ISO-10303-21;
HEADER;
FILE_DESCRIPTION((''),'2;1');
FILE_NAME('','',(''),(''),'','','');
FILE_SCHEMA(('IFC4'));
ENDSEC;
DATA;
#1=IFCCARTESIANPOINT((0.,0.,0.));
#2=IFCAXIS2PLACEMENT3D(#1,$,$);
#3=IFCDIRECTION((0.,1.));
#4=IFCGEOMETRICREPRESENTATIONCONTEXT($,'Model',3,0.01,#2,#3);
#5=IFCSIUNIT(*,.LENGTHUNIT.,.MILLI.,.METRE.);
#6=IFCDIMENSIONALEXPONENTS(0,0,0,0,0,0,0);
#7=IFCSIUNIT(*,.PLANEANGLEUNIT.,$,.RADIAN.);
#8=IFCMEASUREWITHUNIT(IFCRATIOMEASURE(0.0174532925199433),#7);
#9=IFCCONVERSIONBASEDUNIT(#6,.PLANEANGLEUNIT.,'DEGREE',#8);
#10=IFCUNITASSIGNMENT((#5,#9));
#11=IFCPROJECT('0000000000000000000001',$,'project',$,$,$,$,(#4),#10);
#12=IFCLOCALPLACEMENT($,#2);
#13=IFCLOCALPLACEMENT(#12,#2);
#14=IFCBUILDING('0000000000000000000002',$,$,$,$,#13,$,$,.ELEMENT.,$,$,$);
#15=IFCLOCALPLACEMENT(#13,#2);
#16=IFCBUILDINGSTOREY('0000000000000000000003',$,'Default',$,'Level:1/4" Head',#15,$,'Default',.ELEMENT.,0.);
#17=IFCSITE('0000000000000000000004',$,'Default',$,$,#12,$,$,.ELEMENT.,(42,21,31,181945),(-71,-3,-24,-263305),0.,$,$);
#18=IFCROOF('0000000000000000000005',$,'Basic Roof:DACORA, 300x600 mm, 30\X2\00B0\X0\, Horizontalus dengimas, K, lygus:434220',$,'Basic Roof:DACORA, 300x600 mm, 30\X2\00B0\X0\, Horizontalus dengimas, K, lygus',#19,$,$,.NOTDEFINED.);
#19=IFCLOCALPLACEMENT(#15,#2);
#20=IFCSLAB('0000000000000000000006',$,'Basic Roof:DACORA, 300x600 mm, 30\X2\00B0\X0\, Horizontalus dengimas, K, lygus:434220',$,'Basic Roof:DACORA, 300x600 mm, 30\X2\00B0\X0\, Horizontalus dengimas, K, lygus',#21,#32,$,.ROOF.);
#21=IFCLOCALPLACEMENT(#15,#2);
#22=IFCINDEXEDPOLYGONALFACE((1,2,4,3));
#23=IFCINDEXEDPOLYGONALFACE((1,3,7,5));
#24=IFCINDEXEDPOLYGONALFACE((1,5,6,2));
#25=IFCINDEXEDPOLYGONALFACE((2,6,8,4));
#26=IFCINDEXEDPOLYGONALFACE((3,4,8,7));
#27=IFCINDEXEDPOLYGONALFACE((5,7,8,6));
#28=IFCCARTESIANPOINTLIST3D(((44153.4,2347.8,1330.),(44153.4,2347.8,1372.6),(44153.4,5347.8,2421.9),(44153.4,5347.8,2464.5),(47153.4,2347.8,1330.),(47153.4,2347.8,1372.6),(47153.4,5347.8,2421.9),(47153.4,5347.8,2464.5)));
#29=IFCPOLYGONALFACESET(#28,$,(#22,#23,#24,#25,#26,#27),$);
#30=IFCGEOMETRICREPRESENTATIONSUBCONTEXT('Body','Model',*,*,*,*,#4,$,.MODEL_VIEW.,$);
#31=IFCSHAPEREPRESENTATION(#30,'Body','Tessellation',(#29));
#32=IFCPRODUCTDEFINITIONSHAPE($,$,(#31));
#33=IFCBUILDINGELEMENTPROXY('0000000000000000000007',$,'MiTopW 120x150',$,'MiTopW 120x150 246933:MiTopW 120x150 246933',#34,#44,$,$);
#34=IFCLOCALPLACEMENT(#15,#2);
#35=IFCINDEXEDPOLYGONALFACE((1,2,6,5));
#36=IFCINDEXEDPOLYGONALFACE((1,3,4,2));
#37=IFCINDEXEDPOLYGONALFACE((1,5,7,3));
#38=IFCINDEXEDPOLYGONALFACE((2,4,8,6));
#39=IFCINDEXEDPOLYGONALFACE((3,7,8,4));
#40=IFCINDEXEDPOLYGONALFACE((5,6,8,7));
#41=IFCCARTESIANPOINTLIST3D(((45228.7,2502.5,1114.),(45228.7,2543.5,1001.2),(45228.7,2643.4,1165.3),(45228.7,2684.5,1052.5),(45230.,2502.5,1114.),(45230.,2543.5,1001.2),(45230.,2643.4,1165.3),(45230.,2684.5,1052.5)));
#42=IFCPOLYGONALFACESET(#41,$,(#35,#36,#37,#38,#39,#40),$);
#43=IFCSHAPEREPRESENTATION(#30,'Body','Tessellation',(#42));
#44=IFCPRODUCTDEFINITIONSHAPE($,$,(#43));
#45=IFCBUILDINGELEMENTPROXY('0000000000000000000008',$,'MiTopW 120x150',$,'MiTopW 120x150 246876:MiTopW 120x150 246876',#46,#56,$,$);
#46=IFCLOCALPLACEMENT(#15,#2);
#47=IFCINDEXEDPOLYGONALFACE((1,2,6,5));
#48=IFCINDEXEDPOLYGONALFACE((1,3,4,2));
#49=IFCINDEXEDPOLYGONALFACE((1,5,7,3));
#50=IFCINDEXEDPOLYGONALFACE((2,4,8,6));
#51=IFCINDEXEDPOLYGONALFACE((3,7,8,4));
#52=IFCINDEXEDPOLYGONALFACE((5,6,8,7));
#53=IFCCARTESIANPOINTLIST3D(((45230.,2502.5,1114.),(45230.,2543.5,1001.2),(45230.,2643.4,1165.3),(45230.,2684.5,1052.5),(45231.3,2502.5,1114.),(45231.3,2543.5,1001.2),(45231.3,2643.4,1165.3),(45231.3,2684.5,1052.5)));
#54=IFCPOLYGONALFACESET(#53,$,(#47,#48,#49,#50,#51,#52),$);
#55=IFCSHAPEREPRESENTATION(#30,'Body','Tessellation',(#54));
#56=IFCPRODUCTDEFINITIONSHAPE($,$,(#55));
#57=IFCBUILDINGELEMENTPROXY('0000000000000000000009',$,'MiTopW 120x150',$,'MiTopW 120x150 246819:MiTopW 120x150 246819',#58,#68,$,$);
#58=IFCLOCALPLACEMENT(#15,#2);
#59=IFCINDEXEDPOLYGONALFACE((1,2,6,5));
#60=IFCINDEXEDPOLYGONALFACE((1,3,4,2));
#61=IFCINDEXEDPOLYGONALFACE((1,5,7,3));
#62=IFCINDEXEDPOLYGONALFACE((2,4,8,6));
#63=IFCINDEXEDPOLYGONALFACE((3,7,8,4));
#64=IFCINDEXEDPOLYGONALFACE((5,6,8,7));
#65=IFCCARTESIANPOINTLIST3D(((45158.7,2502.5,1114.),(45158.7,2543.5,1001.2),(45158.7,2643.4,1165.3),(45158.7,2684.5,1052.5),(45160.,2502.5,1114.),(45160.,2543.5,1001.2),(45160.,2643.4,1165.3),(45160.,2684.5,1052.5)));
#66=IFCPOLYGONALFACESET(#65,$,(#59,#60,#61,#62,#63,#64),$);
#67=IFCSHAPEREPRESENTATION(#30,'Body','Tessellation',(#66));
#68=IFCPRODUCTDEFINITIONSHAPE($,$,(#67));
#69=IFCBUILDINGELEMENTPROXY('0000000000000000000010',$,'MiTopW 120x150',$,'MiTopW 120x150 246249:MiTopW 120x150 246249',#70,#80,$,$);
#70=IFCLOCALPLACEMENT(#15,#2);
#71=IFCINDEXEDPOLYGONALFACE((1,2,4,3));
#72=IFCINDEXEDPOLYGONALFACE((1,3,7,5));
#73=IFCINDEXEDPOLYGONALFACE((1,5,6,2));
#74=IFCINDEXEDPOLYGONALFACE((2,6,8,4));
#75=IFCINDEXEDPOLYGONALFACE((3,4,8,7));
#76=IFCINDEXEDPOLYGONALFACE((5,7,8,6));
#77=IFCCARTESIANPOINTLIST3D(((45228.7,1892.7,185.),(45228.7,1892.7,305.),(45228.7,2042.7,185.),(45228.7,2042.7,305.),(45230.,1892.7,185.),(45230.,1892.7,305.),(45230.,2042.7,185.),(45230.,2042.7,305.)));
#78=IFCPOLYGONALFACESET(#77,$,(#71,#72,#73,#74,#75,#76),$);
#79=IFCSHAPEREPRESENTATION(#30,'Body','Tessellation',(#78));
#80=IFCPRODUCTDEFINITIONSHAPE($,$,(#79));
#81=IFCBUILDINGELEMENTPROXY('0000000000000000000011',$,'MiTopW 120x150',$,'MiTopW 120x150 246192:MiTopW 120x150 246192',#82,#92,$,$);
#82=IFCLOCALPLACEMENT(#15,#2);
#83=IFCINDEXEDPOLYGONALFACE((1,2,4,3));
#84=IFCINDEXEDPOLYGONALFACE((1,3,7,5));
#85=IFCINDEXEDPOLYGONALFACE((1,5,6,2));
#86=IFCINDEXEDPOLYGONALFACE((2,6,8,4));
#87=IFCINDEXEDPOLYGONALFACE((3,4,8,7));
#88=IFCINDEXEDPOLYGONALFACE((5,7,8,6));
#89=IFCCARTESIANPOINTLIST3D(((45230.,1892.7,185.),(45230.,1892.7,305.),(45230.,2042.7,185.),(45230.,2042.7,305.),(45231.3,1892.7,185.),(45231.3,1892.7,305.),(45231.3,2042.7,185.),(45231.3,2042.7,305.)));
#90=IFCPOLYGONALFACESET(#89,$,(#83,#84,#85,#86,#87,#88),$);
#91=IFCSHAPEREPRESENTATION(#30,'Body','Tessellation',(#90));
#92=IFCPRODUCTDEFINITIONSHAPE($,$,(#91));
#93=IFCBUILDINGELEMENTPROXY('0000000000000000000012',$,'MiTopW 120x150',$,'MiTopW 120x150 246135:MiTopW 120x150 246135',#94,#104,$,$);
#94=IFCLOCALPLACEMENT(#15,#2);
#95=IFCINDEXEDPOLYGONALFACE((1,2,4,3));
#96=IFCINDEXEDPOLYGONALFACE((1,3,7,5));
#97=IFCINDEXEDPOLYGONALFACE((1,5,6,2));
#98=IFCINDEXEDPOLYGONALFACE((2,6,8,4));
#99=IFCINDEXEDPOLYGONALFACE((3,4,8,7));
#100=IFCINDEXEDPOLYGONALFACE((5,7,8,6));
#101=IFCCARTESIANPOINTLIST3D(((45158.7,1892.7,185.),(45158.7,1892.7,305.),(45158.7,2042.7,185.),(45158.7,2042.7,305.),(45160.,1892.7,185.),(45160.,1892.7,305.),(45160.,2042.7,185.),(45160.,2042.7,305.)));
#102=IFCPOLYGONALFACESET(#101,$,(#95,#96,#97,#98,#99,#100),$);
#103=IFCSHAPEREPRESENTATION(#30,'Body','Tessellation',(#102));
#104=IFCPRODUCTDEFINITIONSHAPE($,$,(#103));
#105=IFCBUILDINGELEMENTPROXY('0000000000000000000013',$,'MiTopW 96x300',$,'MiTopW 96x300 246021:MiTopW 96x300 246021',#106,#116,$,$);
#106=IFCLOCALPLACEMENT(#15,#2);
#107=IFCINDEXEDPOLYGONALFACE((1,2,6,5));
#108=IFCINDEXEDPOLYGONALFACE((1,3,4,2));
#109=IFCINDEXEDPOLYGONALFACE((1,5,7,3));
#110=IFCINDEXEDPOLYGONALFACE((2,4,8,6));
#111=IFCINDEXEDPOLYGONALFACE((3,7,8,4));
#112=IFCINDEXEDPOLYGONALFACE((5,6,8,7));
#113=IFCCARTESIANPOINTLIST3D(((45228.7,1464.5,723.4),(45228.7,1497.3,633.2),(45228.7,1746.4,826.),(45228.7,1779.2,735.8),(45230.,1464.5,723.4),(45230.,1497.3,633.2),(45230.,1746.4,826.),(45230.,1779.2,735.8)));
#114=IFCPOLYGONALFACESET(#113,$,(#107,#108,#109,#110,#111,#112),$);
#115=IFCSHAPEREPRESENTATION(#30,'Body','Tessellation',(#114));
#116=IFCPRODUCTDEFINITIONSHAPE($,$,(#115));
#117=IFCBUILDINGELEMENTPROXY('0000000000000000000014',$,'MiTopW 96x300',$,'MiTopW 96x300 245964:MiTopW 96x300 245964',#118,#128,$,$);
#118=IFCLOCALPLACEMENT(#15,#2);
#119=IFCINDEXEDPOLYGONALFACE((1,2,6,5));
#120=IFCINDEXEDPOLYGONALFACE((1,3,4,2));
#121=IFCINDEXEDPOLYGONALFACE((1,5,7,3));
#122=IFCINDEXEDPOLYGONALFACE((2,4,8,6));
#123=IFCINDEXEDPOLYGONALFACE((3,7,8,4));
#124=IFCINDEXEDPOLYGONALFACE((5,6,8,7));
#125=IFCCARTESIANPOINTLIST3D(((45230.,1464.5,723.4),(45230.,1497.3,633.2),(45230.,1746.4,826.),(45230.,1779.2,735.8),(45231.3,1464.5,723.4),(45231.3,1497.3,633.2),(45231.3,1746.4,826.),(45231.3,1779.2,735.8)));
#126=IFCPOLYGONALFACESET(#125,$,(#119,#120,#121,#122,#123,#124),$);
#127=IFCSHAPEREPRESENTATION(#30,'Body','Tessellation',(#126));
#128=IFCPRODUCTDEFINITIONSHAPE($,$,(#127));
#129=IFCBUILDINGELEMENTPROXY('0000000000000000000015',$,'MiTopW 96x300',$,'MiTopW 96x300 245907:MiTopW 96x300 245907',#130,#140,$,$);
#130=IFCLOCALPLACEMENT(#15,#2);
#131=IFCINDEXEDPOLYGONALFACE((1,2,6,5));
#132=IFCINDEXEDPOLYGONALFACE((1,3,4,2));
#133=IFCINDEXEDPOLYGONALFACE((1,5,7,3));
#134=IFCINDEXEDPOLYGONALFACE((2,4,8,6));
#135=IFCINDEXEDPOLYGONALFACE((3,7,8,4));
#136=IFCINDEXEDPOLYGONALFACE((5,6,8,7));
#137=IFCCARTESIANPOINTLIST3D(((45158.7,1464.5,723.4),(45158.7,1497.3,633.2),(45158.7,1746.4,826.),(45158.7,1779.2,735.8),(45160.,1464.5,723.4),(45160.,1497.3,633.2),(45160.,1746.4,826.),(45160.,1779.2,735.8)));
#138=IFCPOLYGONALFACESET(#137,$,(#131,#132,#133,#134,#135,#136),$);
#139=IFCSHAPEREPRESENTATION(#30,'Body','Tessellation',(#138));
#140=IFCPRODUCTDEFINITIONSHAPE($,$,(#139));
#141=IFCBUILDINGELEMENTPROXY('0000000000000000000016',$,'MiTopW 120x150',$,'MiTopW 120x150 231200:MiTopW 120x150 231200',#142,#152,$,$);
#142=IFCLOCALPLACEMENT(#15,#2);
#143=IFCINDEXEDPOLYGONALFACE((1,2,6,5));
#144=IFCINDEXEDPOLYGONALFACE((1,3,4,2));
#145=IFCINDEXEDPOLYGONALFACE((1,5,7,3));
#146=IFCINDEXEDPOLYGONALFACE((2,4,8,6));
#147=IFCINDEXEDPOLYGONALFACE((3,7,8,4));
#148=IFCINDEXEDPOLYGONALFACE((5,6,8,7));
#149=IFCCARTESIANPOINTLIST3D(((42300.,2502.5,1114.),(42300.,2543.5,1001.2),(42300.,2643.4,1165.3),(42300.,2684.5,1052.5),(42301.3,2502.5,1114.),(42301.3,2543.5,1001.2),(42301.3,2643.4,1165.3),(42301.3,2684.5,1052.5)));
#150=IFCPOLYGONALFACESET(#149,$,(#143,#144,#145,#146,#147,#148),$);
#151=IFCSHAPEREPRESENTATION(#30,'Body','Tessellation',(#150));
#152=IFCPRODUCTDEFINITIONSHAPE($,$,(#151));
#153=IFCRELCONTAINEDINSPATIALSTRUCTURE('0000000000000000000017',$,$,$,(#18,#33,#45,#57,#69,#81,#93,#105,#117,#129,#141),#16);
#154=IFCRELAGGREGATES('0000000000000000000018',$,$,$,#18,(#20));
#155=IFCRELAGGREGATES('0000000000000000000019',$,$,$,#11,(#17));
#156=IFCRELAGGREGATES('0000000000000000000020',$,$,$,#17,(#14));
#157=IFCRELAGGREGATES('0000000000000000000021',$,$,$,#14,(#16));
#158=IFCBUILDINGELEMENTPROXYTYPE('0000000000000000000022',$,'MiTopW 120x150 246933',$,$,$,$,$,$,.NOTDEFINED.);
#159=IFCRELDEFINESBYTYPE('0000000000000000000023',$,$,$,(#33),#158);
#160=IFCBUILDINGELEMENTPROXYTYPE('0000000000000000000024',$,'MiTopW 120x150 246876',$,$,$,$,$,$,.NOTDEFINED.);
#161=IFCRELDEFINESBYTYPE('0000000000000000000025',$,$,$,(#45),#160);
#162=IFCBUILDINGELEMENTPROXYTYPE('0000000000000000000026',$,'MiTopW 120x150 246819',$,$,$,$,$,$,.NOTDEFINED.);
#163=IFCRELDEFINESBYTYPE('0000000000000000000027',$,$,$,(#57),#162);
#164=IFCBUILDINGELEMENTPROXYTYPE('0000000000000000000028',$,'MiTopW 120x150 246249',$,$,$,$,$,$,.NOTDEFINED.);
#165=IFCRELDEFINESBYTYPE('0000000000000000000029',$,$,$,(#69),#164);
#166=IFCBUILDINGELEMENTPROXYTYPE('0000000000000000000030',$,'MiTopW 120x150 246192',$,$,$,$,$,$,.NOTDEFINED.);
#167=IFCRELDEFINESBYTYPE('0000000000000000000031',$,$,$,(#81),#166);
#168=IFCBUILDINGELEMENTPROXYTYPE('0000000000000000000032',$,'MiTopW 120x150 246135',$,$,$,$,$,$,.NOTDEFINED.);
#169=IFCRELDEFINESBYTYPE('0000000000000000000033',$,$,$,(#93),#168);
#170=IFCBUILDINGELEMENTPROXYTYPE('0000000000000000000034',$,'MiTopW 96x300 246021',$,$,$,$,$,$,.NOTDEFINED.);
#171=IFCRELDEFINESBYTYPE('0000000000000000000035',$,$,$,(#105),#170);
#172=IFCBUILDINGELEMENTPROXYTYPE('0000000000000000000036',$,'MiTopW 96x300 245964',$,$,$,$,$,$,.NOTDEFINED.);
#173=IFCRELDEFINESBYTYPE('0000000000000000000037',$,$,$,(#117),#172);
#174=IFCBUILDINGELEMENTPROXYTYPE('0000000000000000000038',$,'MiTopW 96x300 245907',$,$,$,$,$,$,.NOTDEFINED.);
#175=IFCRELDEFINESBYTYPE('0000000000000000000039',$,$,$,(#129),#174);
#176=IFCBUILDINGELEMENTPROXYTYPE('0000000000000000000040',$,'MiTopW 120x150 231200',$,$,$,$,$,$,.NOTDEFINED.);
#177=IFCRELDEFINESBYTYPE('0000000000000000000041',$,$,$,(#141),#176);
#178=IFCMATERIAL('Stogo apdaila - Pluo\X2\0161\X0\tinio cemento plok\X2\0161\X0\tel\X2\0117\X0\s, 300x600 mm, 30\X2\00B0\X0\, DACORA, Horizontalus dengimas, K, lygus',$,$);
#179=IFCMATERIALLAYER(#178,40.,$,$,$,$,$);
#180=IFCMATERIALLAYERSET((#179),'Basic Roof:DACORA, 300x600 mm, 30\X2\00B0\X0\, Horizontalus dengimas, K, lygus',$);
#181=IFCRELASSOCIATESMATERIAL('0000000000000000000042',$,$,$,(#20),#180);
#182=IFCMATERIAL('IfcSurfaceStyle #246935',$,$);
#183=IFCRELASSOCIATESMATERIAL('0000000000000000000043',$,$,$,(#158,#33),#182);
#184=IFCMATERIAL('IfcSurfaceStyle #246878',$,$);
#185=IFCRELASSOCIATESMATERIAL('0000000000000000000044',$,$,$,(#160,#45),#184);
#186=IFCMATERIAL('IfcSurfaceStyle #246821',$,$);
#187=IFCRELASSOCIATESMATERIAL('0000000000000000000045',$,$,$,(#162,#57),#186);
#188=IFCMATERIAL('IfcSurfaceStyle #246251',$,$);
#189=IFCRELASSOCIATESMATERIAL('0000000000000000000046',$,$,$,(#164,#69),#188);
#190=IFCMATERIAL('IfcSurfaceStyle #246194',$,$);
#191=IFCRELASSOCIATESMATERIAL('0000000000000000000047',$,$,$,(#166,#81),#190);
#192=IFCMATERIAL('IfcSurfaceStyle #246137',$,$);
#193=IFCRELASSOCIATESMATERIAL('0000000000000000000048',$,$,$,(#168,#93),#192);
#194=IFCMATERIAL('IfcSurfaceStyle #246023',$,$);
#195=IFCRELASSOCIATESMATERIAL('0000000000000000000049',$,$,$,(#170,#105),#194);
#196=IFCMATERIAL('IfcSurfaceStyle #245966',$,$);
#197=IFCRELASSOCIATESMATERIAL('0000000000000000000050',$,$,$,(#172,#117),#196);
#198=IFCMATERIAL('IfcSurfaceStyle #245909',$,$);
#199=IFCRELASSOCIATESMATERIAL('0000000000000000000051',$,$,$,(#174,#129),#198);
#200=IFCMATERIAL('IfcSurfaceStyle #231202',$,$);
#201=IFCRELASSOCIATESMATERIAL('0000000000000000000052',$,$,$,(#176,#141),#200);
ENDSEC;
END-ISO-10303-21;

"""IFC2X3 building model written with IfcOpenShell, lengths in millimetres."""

from ifc_helpers import new_model, entity, si_unit, converted_unit, direction, frame, frame_2d, origin, origin_2d_with_axis, place, context, subcontext, project, spatial, polyline, rectangle, outline, extrude, source, transform, mapped, material, layer, layer_set, type_object, type_shapes, element, aggregate, save


model = new_model("IFC2X3")

# Units and contexts
model_context = context("Model", 3, precision=0.01, world=origin(), true_north=direction((0.0, 1.0)))
body_context = subcontext(model_context, "Body", "Model", "MODEL_VIEW")
ifc_project = project(units=[si_unit("LENGTHUNIT", "METRE", prefix="MILLI"), converted_unit("PLANEANGLEUNIT", "DEGREE", entity("IfcRatioMeasure", 0.0174532925199433), si_unit("PLANEANGLEUNIT", "RADIAN"), dimensions=[0, 0, 0, 0, 0, 0, 0])], contexts=[model_context])

# Site, building, storey
site_placement = place(None, origin())
site = spatial("IfcSite", under=ifc_project, at=site_placement, Name="Default", CompositionType="ELEMENT", RefLatitude=(42, 21, 31, 181945), RefLongitude=(-71, -3, -24, -263305), RefElevation=0.0)
building_placement = place(site_placement, origin())
building = spatial("IfcBuilding", under=site, at=building_placement, CompositionType="ELEMENT")
storey_placement = place(building_placement, origin())
storey = spatial("IfcBuildingStorey", under=building, at=storey_placement, Name="Default", ObjectType="Level:1/4\" Head", LongName="Default", CompositionType="ELEMENT", Elevation=0.0)

# Roof, slab
roof_placement = place(storey_placement, frame((44153.4, 2347.8, 1330.0)))
roof = element("IfcRoof", 1, at=roof_placement, inside=storey, Name="Basic Roof:DACORA, 300x600 mm, 30°, Horizontalus dengimas, K, lygus:434220", ObjectType="Basic Roof:DACORA, 300x600 mm, 30°, Horizontalus dengimas, K, lygus", ShapeType="NOTDEFINED")
ifc_material_1 = material(Name="Stogo apdaila - Pluoštinio cemento plokštelės, 300x600 mm, 30°, DACORA, Horizontalus dengimas, K, lygus")
ifc_layer = layer(ifc_material_1, 40.0)
ifc_layer_set = layer_set([ifc_layer], Name="Basic Roof:DACORA, 300x600 mm, 30°, Horizontalus dengimas, K, lygus")
slab_placement = place(roof_placement, origin())
slab = element("IfcSlab", 2, at=slab_placement, material=ifc_layer_set, Name="Basic Roof:DACORA, 300x600 mm, 30°, Horizontalus dengimas, K, lygus:434220", ObjectType="Basic Roof:DACORA, 300x600 mm, 30°, Horizontalus dengimas, K, lygus", PredefinedType="ROOF", context=body_context, shape_type="SweptSolid", body=[
    extrude(rectangle(XDim=3192.5, YDim=3000.0, at=frame_2d((0.0, 0.0), x_axis=(0.0, -1.0))), frame((1500.0, 1500.0, 546.0), z_axis=(0.0, -0.34202, 0.939693), x_axis=(1.0, 0.0, 0.0)), (0.0, 0.34202, 0.939693), 42.6),
])
aggregate(roof, [slab])

# Building element proxies
ifc_material_2 = material(Name="IfcSurfaceStyle #246935")
building_element_proxy_type_1 = type_object("IfcBuildingElementProxyType", Name="MiTopW 120x150 246933", PredefinedType="NOTDEFINED", material=ifc_material_2)
shared_shape_1 = source(origin(), body_context, "Body", "SweptSolid", [
    extrude(outline(polyline([(-75.0, -60.0), (75.0, -60.0), (75.0, 60.0), (-75.0, 60.0), (-75.0, -60.0)])), frame((75.0, 60.0, 0.0), z_axis=(0.0, 0.0, 1.0), x_axis=(-1.0, 0.0, 0.0)), (0.0, 0.0, 1.0), 1.3),
])
type_shapes(building_element_proxy_type_1, [shared_shape_1])
proxy_1_placement = place(building_placement, frame((45230.0, 2502.5, 1114.0), z_axis=(-1.0, 0.0, 0.0), x_axis=(0.0, 0.939693, 0.34202)))
element("IfcBuildingElementProxy", 3, at=proxy_1_placement, inside=storey, type_object=building_element_proxy_type_1, material=ifc_material_2, Name="MiTopW 120x150", ObjectType="MiTopW 120x150 246933:MiTopW 120x150 246933", context=body_context, shape_type="MappedRepresentation", body=[
    mapped(shared_shape_1, transform((0.0, 0.0, 0.0), scale=1.0)),
])
ifc_material_3 = material(Name="IfcSurfaceStyle #246878")
building_element_proxy_type_2 = type_object("IfcBuildingElementProxyType", Name="MiTopW 120x150 246876", PredefinedType="NOTDEFINED", material=ifc_material_3)
shared_shape_2 = source(origin(), body_context, "Body", "SweptSolid", [
    extrude(outline(polyline([(-75.0, -60.0), (75.0, -60.0), (75.0, 60.0), (-75.0, 60.0), (-75.0, -60.0)])), frame((75.0, 60.0, 0.0), z_axis=(0.0, 0.0, 1.0), x_axis=(-1.0, 0.0, 0.0)), (0.0, 0.0, 1.0), 1.3),
])
type_shapes(building_element_proxy_type_2, [shared_shape_2])
proxy_2_placement = place(building_placement, frame((45231.3, 2502.5, 1114.0), z_axis=(-1.0, 0.0, 0.0), x_axis=(0.0, 0.939693, 0.34202)))
element("IfcBuildingElementProxy", 4, at=proxy_2_placement, inside=storey, type_object=building_element_proxy_type_2, material=ifc_material_3, Name="MiTopW 120x150", ObjectType="MiTopW 120x150 246876:MiTopW 120x150 246876", context=body_context, shape_type="MappedRepresentation", body=[
    mapped(shared_shape_2, transform((0.0, 0.0, 0.0), scale=1.0)),
])
ifc_material_4 = material(Name="IfcSurfaceStyle #246821")
building_element_proxy_type_3 = type_object("IfcBuildingElementProxyType", Name="MiTopW 120x150 246819", PredefinedType="NOTDEFINED", material=ifc_material_4)
shared_shape_3 = source(origin(), body_context, "Body", "SweptSolid", [
    extrude(outline(polyline([(-75.0, -60.0), (75.0, -60.0), (75.0, 60.0), (-75.0, 60.0), (-75.0, -60.0)])), frame((75.0, 60.0, 0.0), z_axis=(0.0, 0.0, 1.0), x_axis=(-1.0, 0.0, 0.0)), (0.0, 0.0, 1.0), 1.3),
])
type_shapes(building_element_proxy_type_3, [shared_shape_3])
proxy_3_placement = place(building_placement, frame((45160.0, 2502.5, 1114.0), z_axis=(-1.0, 0.0, 0.0), x_axis=(0.0, 0.939693, 0.34202)))
element("IfcBuildingElementProxy", 5, at=proxy_3_placement, inside=storey, type_object=building_element_proxy_type_3, material=ifc_material_4, Name="MiTopW 120x150", ObjectType="MiTopW 120x150 246819:MiTopW 120x150 246819", context=body_context, shape_type="MappedRepresentation", body=[
    mapped(shared_shape_3, transform((0.0, 0.0, 0.0), scale=1.0)),
])
ifc_material_5 = material(Name="IfcSurfaceStyle #246251")
building_element_proxy_type_4 = type_object("IfcBuildingElementProxyType", Name="MiTopW 120x150 246249", PredefinedType="NOTDEFINED", material=ifc_material_5)
shared_shape_4 = source(origin(), body_context, "Body", "SweptSolid", [
    extrude(rectangle(XDim=150.0, YDim=120.0, at=origin_2d_with_axis()), frame((75.0, 60.0, 0.0), z_axis=(0.0, 0.0, 1.0), x_axis=(-1.0, 0.0, 0.0)), (0.0, 0.0, 1.0), 1.3),
])
type_shapes(building_element_proxy_type_4, [shared_shape_4])
proxy_4_placement = place(building_placement, frame((45230.0, 1892.7, 305.0), z_axis=(-1.0, 0.0, 0.0), x_axis=(0.0, 1.0, 0.0)))
element("IfcBuildingElementProxy", 6, at=proxy_4_placement, inside=storey, type_object=building_element_proxy_type_4, material=ifc_material_5, Name="MiTopW 120x150", ObjectType="MiTopW 120x150 246249:MiTopW 120x150 246249", context=body_context, shape_type="MappedRepresentation", body=[
    mapped(shared_shape_4, transform((0.0, 0.0, 0.0), scale=1.0)),
])
ifc_material_6 = material(Name="IfcSurfaceStyle #246194")
building_element_proxy_type_5 = type_object("IfcBuildingElementProxyType", Name="MiTopW 120x150 246192", PredefinedType="NOTDEFINED", material=ifc_material_6)
shared_shape_5 = source(origin(), body_context, "Body", "SweptSolid", [
    extrude(rectangle(XDim=150.0, YDim=120.0, at=origin_2d_with_axis()), frame((75.0, 60.0, 0.0), z_axis=(0.0, 0.0, 1.0), x_axis=(-1.0, 0.0, 0.0)), (0.0, 0.0, 1.0), 1.3),
])
type_shapes(building_element_proxy_type_5, [shared_shape_5])
proxy_5_placement = place(building_placement, frame((45231.3, 1892.7, 305.0), z_axis=(-1.0, 0.0, 0.0), x_axis=(0.0, 1.0, 0.0)))
element("IfcBuildingElementProxy", 7, at=proxy_5_placement, inside=storey, type_object=building_element_proxy_type_5, material=ifc_material_6, Name="MiTopW 120x150", ObjectType="MiTopW 120x150 246192:MiTopW 120x150 246192", context=body_context, shape_type="MappedRepresentation", body=[
    mapped(shared_shape_5, transform((0.0, 0.0, 0.0), scale=1.0)),
])
ifc_material_7 = material(Name="IfcSurfaceStyle #246137")
building_element_proxy_type_6 = type_object("IfcBuildingElementProxyType", Name="MiTopW 120x150 246135", PredefinedType="NOTDEFINED", material=ifc_material_7)
shared_shape_6 = source(origin(), body_context, "Body", "SweptSolid", [
    extrude(rectangle(XDim=150.0, YDim=120.0, at=origin_2d_with_axis()), frame((75.0, 60.0, 0.0), z_axis=(0.0, 0.0, 1.0), x_axis=(-1.0, 0.0, 0.0)), (0.0, 0.0, 1.0), 1.3),
])
type_shapes(building_element_proxy_type_6, [shared_shape_6])
proxy_6_placement = place(building_placement, frame((45160.0, 1892.7, 305.0), z_axis=(-1.0, 0.0, 0.0), x_axis=(0.0, 1.0, 0.0)))
element("IfcBuildingElementProxy", 8, at=proxy_6_placement, inside=storey, type_object=building_element_proxy_type_6, material=ifc_material_7, Name="MiTopW 120x150", ObjectType="MiTopW 120x150 246135:MiTopW 120x150 246135", context=body_context, shape_type="MappedRepresentation", body=[
    mapped(shared_shape_6, transform((0.0, 0.0, 0.0), scale=1.0)),
])
ifc_material_8 = material(Name="IfcSurfaceStyle #246023")
building_element_proxy_type_7 = type_object("IfcBuildingElementProxyType", Name="MiTopW 96x300 246021", PredefinedType="NOTDEFINED", material=ifc_material_8)
shared_shape_7 = source(origin(), body_context, "Body", "SweptSolid", [
    extrude(outline(polyline([(-150.0, -48.0), (150.0, -48.0), (150.0, 48.0), (-150.0, 48.0), (-150.0, -48.0)])), frame((150.0, 48.0, 0.0), z_axis=(0.0, 0.0, 1.0), x_axis=(-1.0, 0.0, 0.0)), (0.0, 0.0, 1.0), 1.3),
])
type_shapes(building_element_proxy_type_7, [shared_shape_7])
proxy_7_placement = place(building_placement, frame((45230.0, 1464.5, 723.4), z_axis=(-1.0, 0.0, 0.0), x_axis=(0.0, 0.939693, 0.34202)))
element("IfcBuildingElementProxy", 9, at=proxy_7_placement, inside=storey, type_object=building_element_proxy_type_7, material=ifc_material_8, Name="MiTopW 96x300", ObjectType="MiTopW 96x300 246021:MiTopW 96x300 246021", context=body_context, shape_type="MappedRepresentation", body=[
    mapped(shared_shape_7, transform((0.0, 0.0, 0.0), scale=1.0)),
])
ifc_material_9 = material(Name="IfcSurfaceStyle #245966")
building_element_proxy_type_8 = type_object("IfcBuildingElementProxyType", Name="MiTopW 96x300 245964", PredefinedType="NOTDEFINED", material=ifc_material_9)
shared_shape_8 = source(origin(), body_context, "Body", "SweptSolid", [
    extrude(outline(polyline([(-150.0, -48.0), (150.0, -48.0), (150.0, 48.0), (-150.0, 48.0), (-150.0, -48.0)])), frame((150.0, 48.0, 0.0), z_axis=(0.0, 0.0, 1.0), x_axis=(-1.0, 0.0, 0.0)), (0.0, 0.0, 1.0), 1.3),
])
type_shapes(building_element_proxy_type_8, [shared_shape_8])
proxy_8_placement = place(building_placement, frame((45231.3, 1464.5, 723.4), z_axis=(-1.0, 0.0, 0.0), x_axis=(0.0, 0.939693, 0.34202)))
element("IfcBuildingElementProxy", 10, at=proxy_8_placement, inside=storey, type_object=building_element_proxy_type_8, material=ifc_material_9, Name="MiTopW 96x300", ObjectType="MiTopW 96x300 245964:MiTopW 96x300 245964", context=body_context, shape_type="MappedRepresentation", body=[
    mapped(shared_shape_8, transform((0.0, 0.0, 0.0), scale=1.0)),
])
ifc_material_10 = material(Name="IfcSurfaceStyle #245909")
building_element_proxy_type_9 = type_object("IfcBuildingElementProxyType", Name="MiTopW 96x300 245907", PredefinedType="NOTDEFINED", material=ifc_material_10)
shared_shape_9 = source(origin(), body_context, "Body", "SweptSolid", [
    extrude(outline(polyline([(-150.0, -48.0), (150.0, -48.0), (150.0, 48.0), (-150.0, 48.0), (-150.0, -48.0)])), frame((150.0, 48.0, 0.0), z_axis=(0.0, 0.0, 1.0), x_axis=(-1.0, 0.0, 0.0)), (0.0, 0.0, 1.0), 1.3),
])
type_shapes(building_element_proxy_type_9, [shared_shape_9])
proxy_9_placement = place(building_placement, frame((45160.0, 1464.5, 723.4), z_axis=(-1.0, 0.0, 0.0), x_axis=(0.0, 0.939693, 0.34202)))
element("IfcBuildingElementProxy", 11, at=proxy_9_placement, inside=storey, type_object=building_element_proxy_type_9, material=ifc_material_10, Name="MiTopW 96x300", ObjectType="MiTopW 96x300 245907:MiTopW 96x300 245907", context=body_context, shape_type="MappedRepresentation", body=[
    mapped(shared_shape_9, transform((0.0, 0.0, 0.0), scale=1.0)),
])
ifc_material_11 = material(Name="IfcSurfaceStyle #231202")
building_element_proxy_type_10 = type_object("IfcBuildingElementProxyType", Name="MiTopW 120x150 231200", PredefinedType="NOTDEFINED", material=ifc_material_11)
shared_shape_10 = source(origin(), body_context, "Body", "SweptSolid", [
    extrude(outline(polyline([(-75.0, -60.0), (75.0, -60.0), (75.0, 60.0), (-75.0, 60.0), (-75.0, -60.0)])), frame((75.0, 60.0, 0.0), z_axis=(0.0, 0.0, 1.0), x_axis=(-1.0, 0.0, 0.0)), (0.0, 0.0, 1.0), 1.3),
])
type_shapes(building_element_proxy_type_10, [shared_shape_10])
proxy_10_placement = place(building_placement, frame((42301.3, 2502.5, 1114.0), z_axis=(-1.0, 0.0, 0.0), x_axis=(0.0, 0.939693, 0.34202)))
element("IfcBuildingElementProxy", 12, at=proxy_10_placement, inside=storey, type_object=building_element_proxy_type_10, material=ifc_material_11, Name="MiTopW 120x150", ObjectType="MiTopW 120x150 231200:MiTopW 120x150 231200", context=body_context, shape_type="MappedRepresentation", body=[
    mapped(shared_shape_10, transform((0.0, 0.0, 0.0), scale=1.0)),
])

save(model, "model.ifc")
